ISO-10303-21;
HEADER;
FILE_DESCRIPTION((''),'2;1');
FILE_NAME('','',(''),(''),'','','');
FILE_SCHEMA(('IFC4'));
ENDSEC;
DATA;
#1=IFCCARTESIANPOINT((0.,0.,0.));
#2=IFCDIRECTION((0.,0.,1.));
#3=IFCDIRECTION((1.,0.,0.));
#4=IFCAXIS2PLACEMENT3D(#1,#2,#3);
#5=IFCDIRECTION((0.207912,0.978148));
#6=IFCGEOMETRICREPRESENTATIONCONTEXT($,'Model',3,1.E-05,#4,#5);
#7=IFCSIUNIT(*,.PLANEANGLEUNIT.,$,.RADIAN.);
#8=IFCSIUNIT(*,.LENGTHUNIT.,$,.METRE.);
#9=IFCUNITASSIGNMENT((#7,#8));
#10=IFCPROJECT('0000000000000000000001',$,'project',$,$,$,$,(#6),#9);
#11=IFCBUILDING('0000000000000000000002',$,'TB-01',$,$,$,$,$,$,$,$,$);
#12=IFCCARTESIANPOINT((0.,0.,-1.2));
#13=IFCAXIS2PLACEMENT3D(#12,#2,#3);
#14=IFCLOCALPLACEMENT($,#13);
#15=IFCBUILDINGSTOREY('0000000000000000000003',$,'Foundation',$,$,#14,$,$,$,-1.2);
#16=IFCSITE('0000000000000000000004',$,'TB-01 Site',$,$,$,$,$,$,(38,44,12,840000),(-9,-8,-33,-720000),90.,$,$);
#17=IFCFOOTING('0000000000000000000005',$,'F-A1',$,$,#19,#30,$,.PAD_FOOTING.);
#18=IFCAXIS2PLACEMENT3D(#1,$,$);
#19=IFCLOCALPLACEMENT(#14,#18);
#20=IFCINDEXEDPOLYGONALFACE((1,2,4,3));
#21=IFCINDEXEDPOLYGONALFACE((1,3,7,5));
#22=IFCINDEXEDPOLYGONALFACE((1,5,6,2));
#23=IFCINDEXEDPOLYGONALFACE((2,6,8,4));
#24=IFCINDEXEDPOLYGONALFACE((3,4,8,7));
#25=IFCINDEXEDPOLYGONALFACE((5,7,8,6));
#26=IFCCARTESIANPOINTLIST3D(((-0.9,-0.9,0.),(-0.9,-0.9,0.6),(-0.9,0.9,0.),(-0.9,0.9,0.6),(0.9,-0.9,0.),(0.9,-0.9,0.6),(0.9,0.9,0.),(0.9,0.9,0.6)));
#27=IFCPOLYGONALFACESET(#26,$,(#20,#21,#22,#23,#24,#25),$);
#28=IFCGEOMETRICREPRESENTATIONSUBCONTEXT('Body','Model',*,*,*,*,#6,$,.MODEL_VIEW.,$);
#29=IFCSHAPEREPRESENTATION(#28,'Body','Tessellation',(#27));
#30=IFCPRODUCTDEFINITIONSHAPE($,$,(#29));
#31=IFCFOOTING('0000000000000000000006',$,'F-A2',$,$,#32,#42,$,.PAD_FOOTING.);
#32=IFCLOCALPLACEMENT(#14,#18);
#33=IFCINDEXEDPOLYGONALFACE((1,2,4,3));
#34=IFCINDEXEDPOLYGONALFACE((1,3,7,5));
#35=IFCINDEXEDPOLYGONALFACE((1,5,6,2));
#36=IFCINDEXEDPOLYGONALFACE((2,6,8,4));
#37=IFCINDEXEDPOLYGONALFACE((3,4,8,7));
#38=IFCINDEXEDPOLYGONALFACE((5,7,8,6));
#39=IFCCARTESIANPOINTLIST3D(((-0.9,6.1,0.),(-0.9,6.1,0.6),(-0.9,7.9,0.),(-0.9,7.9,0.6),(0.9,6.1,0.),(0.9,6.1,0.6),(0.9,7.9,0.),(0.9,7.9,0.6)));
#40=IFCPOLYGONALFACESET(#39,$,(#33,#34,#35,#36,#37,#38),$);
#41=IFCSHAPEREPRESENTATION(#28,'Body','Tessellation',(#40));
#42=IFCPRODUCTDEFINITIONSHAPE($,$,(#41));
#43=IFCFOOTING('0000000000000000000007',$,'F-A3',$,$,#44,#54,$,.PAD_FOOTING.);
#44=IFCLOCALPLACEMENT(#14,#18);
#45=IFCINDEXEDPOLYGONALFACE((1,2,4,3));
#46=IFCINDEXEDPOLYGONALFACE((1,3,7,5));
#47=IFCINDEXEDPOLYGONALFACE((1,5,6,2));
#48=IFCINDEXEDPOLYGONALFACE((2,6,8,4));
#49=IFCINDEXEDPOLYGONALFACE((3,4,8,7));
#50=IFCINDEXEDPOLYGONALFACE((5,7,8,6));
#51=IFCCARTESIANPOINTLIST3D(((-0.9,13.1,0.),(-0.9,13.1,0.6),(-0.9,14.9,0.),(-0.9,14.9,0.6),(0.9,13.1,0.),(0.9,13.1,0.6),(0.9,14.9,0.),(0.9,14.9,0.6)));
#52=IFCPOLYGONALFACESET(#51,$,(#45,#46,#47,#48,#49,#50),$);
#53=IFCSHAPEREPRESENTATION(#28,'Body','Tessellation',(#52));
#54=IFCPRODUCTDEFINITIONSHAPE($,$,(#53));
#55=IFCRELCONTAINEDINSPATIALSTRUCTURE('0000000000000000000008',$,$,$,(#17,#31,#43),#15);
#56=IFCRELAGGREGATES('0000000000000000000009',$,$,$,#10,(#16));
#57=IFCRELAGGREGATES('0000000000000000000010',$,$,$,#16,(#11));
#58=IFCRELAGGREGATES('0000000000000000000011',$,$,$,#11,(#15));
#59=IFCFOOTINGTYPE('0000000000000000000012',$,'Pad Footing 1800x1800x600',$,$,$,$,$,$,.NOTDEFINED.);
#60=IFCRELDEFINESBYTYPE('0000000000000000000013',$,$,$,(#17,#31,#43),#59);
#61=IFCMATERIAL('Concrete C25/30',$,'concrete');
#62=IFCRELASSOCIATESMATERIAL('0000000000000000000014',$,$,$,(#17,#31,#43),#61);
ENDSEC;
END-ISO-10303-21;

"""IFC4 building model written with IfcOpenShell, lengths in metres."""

from ifc_helpers import new_model, si_unit, direction, frame, origin_with_axes, place, context, subcontext, project, spatial, rectangle, extrude, material, type_object, element, save


model = new_model("IFC4")

# Units and contexts
model_context = context("Model", 3, precision=1e-05, world=origin_with_axes(), true_north=direction((0.207912, 0.978148)))
body_context = subcontext(model_context, "Body", "Model", "MODEL_VIEW")
ifc_project = project(units=[si_unit("PLANEANGLEUNIT", "RADIAN"), si_unit("LENGTHUNIT", "METRE")], contexts=[model_context])

# Site, building, storey
site = spatial("IfcSite", under=ifc_project, Name="TB-01 Site", RefLatitude=(38, 44, 12, 840000), RefLongitude=(-9, -8, -33, -720000), RefElevation=90.0)
building = spatial("IfcBuilding", under=site, Name="TB-01")
storey_placement = place(None, frame((0.0, 0.0, -1.2), z_axis=(0.0, 0.0, 1.0), x_axis=(1.0, 0.0, 0.0)))
storey = spatial("IfcBuildingStorey", under=building, at=storey_placement, Name="Foundation", Elevation=-1.2)

# Footings
ifc_material_1 = material(Name="Concrete C25/30", Category="concrete")
footing_type = type_object("IfcFootingType", Name="Pad Footing 1800x1800x600", PredefinedType="NOTDEFINED")
footing_placement = place(storey_placement, origin_with_axes())
element("IfcFooting", 1, at=footing_placement, inside=storey, type_object=footing_type, material=ifc_material_1, Name="F-A1", PredefinedType="PAD_FOOTING", context=body_context, shape_type="SweptSolid", body=[
    extrude(rectangle(XDim=1.8, YDim=1.8), origin_with_axes(), (0.0, 0.0, 1.0), 0.6),
])
for number, where, z_axis, x_axis, name in (
    (2, (0.0, 7.0, 0.0), (0.0, 0.0, 1.0), (1.0, 0.0, 0.0), "F-A2"),
    (3, (0.0, 14.0, 0.0), (0.0, 0.0, 1.0), (1.0, 0.0, 0.0), "F-A3"),
):
    element("IfcFooting", number, at=place(storey_placement, frame(where, z_axis=z_axis, x_axis=x_axis)), inside=storey, type_object=footing_type, material=ifc_material_1, Name=name, PredefinedType="PAD_FOOTING", context=body_context, shape_type="SweptSolid", body=[
        extrude(rectangle(XDim=1.8, YDim=1.8), origin_with_axes(), (0.0, 0.0, 1.0), 0.6),
    ])

save(model, "model.ifc")
